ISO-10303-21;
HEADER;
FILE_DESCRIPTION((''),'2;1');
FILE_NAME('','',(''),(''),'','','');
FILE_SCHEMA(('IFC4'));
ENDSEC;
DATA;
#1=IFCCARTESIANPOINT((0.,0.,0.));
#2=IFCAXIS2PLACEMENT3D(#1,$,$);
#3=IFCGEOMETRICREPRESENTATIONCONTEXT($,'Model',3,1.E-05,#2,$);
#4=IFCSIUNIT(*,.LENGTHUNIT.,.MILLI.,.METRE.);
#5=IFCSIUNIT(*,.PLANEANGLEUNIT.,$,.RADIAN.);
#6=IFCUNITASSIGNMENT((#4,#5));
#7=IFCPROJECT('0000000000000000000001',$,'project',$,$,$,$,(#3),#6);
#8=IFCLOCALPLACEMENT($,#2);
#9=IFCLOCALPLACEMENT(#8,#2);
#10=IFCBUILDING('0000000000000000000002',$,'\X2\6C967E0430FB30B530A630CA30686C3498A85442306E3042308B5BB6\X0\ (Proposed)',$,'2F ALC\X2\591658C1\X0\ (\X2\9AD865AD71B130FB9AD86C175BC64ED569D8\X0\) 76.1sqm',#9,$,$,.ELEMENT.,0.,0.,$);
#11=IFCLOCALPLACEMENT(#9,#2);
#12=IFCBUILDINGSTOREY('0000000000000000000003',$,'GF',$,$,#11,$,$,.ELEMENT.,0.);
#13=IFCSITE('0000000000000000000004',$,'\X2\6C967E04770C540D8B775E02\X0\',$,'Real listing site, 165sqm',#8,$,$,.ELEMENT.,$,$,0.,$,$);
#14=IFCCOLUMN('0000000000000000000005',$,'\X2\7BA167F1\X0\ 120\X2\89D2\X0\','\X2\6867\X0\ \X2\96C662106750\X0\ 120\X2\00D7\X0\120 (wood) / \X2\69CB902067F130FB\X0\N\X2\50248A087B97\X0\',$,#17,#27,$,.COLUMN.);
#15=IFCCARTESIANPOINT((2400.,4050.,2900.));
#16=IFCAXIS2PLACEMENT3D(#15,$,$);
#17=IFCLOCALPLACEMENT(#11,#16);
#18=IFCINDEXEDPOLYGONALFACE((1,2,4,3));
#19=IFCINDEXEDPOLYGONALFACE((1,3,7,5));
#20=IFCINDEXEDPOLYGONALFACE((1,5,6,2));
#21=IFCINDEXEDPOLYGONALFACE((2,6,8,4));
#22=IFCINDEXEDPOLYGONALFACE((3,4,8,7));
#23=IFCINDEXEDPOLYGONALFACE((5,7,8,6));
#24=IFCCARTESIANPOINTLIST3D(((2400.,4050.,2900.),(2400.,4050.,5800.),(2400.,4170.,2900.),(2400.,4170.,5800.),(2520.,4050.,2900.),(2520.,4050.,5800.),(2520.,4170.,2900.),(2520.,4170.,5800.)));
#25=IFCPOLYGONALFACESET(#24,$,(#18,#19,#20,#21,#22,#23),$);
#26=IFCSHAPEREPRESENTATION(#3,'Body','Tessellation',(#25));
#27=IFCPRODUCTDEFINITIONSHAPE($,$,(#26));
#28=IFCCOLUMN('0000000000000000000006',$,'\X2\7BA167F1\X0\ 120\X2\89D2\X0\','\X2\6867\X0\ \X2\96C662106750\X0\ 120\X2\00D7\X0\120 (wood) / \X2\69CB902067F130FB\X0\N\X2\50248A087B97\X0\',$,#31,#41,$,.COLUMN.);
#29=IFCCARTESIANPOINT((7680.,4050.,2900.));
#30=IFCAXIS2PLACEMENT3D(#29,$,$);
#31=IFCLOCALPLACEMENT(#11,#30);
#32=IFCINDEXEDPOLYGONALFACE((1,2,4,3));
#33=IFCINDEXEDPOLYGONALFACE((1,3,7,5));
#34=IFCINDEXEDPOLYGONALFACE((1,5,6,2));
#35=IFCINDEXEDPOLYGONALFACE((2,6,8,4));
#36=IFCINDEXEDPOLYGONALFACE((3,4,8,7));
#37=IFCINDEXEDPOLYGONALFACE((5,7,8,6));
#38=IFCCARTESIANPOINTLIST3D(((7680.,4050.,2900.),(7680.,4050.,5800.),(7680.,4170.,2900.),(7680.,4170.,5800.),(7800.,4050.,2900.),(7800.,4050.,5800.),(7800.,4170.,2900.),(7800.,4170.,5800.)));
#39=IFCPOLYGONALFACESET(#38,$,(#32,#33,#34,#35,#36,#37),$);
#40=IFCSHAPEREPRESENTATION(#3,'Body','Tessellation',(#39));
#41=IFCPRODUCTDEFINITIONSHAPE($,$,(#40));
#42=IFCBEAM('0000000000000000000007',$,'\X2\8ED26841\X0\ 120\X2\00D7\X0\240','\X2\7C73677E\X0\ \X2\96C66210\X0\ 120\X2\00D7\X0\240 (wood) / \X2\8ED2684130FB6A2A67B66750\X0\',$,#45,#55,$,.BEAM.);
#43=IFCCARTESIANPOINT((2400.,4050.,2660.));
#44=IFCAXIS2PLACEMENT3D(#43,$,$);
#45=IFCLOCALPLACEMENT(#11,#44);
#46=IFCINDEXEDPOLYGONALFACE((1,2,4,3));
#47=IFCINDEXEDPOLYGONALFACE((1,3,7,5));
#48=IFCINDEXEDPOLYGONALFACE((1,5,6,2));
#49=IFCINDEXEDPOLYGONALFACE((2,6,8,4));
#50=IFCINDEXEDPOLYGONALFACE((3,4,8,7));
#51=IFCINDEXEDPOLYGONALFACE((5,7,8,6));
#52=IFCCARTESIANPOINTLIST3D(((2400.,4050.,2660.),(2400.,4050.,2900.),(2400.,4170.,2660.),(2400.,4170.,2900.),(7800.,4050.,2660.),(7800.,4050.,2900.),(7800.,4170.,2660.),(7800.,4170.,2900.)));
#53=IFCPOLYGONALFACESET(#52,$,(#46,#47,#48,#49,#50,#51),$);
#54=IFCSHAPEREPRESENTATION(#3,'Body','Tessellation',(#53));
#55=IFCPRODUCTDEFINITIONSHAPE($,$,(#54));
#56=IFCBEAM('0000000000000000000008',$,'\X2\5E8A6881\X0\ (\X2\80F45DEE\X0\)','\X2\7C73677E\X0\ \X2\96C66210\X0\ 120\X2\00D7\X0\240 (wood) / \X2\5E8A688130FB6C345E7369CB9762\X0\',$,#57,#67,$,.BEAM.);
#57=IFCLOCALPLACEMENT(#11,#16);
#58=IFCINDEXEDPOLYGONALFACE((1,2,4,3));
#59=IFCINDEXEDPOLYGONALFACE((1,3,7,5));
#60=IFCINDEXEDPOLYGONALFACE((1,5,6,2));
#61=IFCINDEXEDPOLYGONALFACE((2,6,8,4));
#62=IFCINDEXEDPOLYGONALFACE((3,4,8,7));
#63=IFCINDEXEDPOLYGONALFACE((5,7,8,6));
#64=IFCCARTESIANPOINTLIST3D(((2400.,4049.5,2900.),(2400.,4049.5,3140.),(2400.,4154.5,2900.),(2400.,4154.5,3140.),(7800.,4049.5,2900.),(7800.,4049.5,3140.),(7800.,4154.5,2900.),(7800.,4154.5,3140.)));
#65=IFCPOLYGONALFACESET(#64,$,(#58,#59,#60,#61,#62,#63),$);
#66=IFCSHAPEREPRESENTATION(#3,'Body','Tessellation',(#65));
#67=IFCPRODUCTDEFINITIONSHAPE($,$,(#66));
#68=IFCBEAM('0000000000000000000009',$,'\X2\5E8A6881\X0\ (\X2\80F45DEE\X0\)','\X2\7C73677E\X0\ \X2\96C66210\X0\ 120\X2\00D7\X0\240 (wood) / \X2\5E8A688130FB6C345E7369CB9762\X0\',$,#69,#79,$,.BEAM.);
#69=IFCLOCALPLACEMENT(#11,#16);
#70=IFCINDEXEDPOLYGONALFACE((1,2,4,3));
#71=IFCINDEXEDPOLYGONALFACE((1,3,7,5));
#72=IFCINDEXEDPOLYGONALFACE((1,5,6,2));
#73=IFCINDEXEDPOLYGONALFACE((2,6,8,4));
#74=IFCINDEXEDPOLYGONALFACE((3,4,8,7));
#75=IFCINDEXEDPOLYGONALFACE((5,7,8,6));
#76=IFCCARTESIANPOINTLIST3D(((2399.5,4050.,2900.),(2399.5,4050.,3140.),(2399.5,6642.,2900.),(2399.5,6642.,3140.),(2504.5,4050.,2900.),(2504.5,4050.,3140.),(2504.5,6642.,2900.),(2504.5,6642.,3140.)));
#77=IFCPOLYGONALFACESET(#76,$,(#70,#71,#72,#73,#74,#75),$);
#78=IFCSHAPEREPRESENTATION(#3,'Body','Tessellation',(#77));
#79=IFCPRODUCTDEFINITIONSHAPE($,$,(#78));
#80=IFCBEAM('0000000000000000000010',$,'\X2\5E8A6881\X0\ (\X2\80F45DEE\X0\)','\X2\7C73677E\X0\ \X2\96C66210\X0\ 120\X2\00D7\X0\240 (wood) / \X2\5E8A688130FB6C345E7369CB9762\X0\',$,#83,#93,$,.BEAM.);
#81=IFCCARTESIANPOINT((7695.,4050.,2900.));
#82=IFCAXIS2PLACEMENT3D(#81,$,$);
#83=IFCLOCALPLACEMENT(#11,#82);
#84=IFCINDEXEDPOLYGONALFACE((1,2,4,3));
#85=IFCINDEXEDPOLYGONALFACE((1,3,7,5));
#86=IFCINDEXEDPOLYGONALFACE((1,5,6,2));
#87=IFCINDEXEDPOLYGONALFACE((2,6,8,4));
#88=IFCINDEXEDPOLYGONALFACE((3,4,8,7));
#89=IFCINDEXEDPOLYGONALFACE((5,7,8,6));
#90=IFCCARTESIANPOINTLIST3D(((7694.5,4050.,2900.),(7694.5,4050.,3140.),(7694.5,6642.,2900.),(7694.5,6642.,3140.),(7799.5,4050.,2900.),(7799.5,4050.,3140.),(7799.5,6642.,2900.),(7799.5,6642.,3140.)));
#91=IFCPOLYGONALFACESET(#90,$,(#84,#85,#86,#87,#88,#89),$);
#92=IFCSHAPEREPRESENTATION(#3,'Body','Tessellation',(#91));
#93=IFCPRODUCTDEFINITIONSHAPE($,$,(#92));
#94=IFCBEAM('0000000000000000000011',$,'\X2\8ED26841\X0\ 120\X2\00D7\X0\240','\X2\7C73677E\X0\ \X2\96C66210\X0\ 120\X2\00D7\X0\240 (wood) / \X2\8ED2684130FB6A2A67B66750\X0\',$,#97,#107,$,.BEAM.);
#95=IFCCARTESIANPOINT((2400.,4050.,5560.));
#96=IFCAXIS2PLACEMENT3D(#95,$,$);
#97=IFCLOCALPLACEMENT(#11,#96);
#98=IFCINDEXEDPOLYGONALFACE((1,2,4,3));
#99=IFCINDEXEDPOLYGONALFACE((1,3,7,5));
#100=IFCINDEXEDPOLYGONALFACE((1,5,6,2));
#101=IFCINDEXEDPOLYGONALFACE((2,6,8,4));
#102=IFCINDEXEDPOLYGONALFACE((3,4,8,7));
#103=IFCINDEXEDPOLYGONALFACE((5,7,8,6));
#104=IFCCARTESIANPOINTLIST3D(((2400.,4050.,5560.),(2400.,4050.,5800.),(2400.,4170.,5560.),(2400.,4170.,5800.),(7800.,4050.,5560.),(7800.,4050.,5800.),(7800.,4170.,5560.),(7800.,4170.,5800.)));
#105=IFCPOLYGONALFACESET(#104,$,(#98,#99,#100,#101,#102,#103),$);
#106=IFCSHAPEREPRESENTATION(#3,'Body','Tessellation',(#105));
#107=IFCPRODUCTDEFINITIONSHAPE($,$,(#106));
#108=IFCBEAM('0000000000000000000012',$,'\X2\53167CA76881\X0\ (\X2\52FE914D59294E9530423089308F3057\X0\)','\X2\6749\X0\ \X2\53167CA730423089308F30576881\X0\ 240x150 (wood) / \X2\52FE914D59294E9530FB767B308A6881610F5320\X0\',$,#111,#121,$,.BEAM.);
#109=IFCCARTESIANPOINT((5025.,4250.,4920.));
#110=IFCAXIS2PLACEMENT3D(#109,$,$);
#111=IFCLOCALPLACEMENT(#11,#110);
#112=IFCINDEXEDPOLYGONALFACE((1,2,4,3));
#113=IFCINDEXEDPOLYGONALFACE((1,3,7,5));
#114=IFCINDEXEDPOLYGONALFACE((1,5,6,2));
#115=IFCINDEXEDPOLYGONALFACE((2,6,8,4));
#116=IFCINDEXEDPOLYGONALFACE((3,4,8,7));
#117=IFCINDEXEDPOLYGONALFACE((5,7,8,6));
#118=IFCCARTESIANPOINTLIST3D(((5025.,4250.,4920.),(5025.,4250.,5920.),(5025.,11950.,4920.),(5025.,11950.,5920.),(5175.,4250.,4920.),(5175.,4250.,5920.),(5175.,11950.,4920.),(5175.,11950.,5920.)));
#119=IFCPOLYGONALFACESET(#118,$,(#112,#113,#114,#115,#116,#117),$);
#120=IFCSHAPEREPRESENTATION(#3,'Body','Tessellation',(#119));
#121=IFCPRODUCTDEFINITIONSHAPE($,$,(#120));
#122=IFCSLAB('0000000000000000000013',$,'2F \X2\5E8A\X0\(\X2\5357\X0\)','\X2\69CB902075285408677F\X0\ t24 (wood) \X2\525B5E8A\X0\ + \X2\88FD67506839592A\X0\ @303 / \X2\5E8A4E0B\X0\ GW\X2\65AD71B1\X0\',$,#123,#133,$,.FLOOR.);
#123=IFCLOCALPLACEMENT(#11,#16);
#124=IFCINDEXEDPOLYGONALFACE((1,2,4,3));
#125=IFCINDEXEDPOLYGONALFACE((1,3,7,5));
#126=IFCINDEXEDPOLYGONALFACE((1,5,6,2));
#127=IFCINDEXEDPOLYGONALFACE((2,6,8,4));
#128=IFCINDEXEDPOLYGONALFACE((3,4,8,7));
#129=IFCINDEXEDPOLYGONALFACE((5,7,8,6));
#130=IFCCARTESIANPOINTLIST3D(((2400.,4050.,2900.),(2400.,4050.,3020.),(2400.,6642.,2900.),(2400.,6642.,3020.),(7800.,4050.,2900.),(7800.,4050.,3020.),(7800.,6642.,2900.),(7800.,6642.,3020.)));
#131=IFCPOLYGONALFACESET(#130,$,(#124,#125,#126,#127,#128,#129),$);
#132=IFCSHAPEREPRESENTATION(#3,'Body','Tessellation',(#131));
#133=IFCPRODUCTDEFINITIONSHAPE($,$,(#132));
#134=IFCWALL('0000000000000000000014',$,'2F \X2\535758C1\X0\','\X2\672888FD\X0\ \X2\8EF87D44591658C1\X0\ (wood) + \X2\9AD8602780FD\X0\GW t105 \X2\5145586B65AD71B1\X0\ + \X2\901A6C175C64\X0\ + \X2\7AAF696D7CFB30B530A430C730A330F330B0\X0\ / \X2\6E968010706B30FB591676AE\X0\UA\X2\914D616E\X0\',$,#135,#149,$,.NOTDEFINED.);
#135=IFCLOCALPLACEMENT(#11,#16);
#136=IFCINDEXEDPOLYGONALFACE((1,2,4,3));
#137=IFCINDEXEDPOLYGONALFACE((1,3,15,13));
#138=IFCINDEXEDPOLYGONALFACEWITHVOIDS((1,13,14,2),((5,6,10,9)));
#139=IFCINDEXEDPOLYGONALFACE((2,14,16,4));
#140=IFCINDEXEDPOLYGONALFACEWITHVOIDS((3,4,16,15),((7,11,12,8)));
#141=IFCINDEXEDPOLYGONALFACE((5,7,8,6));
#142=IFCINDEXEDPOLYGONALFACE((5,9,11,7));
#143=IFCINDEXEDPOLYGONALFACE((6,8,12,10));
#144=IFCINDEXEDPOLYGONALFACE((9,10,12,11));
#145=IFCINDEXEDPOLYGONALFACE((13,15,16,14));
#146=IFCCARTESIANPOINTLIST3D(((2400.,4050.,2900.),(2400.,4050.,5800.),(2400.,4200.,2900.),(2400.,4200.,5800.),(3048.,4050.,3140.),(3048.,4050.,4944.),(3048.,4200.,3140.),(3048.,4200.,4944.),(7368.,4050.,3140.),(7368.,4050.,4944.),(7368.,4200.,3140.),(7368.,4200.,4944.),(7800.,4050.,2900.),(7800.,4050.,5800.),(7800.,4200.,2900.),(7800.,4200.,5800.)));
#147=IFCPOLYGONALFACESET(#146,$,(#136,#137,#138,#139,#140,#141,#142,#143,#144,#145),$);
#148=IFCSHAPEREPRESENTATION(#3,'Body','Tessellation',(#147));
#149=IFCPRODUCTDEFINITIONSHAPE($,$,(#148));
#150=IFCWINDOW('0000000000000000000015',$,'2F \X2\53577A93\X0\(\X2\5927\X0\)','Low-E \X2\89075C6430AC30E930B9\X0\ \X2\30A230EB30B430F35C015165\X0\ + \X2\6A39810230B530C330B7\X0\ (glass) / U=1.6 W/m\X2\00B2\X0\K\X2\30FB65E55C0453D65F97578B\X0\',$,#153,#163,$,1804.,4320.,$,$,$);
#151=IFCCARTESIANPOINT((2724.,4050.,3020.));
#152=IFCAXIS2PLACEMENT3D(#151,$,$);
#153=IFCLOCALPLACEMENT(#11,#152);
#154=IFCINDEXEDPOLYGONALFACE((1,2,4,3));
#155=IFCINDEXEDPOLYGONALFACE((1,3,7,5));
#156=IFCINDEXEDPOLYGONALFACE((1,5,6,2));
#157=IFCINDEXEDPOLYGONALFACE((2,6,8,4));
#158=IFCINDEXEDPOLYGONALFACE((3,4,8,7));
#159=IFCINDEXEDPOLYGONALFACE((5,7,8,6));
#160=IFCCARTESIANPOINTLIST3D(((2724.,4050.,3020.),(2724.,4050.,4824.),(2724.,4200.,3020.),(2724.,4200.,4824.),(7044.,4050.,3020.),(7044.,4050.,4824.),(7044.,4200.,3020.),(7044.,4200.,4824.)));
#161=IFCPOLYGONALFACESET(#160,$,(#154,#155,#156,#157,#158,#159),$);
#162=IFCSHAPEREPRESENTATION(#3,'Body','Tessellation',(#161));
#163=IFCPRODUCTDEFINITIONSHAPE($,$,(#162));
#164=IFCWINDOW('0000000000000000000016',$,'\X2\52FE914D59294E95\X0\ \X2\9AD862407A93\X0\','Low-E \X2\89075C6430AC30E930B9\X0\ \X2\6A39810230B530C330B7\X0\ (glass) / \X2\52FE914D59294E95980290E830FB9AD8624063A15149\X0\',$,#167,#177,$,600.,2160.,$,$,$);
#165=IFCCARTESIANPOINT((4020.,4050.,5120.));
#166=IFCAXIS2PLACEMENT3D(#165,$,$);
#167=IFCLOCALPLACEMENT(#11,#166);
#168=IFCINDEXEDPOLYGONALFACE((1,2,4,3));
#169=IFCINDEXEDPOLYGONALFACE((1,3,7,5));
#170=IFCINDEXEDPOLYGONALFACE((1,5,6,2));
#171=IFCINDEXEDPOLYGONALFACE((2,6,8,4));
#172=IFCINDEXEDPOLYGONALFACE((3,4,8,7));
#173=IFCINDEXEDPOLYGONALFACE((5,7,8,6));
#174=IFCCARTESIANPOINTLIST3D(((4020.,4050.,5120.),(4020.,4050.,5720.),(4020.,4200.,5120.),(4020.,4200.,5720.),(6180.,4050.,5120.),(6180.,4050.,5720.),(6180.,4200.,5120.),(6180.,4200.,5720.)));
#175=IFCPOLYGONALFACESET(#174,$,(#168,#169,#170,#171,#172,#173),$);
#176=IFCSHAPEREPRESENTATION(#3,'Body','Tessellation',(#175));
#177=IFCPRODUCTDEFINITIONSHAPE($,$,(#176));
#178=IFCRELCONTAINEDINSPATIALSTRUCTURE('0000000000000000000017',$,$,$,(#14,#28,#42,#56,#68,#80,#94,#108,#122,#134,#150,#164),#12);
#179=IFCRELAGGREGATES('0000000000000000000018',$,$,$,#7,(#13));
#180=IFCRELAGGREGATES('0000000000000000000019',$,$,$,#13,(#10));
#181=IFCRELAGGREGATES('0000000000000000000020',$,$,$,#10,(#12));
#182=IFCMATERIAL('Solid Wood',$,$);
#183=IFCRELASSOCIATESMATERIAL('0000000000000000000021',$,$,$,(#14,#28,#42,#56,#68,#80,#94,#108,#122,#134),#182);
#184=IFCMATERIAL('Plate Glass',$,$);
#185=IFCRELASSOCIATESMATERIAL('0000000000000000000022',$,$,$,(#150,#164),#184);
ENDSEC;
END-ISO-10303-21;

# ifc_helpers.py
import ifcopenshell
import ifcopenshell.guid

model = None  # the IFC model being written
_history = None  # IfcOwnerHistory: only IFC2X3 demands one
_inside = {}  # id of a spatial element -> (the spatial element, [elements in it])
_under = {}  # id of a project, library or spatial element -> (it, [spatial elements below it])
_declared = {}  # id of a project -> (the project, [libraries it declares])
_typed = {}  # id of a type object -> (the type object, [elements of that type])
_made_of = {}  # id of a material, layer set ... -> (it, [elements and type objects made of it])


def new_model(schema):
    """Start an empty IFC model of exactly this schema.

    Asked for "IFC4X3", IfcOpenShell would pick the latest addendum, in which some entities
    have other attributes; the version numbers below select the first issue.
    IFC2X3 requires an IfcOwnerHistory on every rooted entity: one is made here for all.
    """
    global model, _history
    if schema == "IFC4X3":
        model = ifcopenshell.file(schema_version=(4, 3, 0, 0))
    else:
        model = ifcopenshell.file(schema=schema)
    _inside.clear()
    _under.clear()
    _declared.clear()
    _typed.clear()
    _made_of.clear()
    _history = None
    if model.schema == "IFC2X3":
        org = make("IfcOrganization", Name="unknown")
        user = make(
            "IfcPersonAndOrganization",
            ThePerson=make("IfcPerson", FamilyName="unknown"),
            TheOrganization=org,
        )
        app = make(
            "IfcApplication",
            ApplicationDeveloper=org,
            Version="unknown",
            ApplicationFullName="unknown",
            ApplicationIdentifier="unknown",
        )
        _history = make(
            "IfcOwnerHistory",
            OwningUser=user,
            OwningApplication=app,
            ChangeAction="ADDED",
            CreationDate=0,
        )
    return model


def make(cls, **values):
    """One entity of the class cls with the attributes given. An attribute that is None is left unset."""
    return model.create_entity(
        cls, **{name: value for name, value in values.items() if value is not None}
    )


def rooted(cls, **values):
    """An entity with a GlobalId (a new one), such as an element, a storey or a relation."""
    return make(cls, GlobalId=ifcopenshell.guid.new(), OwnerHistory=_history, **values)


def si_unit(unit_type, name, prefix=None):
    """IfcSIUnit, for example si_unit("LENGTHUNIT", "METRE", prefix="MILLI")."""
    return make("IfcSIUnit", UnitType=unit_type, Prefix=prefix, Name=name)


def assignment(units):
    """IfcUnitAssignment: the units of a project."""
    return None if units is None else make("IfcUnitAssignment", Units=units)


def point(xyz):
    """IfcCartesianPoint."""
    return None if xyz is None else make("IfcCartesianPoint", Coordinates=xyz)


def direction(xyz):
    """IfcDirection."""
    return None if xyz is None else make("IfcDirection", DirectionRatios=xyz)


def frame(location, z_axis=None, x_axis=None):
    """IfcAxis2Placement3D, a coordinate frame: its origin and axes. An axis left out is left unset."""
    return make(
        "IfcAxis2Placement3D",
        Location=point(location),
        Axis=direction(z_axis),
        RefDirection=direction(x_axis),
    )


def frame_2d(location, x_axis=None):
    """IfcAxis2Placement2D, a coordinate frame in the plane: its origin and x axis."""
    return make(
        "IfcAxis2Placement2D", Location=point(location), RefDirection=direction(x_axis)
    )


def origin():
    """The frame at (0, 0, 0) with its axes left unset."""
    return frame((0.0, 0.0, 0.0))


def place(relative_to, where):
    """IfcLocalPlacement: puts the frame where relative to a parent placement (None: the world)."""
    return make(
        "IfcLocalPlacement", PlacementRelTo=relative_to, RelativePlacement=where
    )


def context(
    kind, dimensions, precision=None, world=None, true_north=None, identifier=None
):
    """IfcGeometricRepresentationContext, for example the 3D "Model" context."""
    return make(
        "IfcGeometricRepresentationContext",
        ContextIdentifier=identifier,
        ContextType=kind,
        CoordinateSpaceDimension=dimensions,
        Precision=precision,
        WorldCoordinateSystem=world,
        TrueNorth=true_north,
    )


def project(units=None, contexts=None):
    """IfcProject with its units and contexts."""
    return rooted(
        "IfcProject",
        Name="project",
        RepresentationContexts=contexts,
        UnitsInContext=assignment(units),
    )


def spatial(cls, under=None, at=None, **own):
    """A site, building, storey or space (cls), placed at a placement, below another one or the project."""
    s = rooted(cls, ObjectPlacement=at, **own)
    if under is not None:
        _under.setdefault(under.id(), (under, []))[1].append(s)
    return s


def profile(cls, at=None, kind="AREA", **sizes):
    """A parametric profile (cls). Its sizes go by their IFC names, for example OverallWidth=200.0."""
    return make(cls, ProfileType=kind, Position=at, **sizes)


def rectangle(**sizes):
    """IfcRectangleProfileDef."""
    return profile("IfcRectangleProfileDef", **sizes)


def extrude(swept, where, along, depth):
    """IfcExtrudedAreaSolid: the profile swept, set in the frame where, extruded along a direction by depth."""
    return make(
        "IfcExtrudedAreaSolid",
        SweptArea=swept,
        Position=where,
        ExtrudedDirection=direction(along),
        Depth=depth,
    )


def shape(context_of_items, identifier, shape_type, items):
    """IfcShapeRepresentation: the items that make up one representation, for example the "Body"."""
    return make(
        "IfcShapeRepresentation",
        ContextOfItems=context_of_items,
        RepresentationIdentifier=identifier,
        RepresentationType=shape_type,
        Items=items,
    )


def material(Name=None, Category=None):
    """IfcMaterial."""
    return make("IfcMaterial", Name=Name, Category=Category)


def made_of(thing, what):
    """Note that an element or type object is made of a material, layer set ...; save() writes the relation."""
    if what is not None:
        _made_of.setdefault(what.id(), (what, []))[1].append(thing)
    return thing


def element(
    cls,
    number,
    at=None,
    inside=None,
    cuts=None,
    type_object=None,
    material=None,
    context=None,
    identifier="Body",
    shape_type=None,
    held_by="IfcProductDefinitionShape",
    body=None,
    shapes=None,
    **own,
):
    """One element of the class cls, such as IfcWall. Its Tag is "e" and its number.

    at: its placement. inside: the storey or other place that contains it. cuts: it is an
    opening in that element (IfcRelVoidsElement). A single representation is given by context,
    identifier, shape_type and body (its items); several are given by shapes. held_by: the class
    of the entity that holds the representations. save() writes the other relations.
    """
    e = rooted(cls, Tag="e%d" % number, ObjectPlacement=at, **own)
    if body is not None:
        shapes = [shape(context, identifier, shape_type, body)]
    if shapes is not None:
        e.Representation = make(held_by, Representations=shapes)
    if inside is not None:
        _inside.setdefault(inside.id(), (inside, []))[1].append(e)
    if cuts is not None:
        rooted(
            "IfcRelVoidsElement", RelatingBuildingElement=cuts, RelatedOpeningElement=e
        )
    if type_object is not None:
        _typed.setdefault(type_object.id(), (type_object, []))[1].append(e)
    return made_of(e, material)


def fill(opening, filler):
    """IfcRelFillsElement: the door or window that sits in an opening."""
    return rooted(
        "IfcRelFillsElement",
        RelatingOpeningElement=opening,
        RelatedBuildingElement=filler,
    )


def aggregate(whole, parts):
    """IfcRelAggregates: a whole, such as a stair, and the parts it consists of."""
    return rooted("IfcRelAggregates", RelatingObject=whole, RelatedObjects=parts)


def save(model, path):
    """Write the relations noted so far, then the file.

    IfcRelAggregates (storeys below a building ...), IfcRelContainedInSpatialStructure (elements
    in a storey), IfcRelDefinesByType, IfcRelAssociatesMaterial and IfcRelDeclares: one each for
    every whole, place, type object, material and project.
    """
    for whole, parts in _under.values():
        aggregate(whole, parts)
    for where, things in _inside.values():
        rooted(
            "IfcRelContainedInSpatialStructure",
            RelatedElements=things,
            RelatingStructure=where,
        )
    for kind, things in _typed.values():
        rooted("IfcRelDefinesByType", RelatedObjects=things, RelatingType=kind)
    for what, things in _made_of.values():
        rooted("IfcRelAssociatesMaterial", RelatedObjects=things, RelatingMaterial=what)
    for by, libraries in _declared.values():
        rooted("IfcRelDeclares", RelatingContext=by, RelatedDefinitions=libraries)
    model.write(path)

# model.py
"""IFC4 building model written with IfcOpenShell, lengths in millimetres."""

from ifc_helpers import new_model, si_unit, frame, frame_2d, origin, place, context, project, spatial, rectangle, extrude, material, element, fill, save


model = new_model("IFC4")

# Units and contexts
model_context = context("Model", 3, precision=1e-05, world=origin())
ifc_project = project(units=[si_unit("LENGTHUNIT", "METRE", prefix="MILLI"), si_unit("PLANEANGLEUNIT", "RADIAN")], contexts=[model_context])

# Site, building, storey
site_placement = place(None, origin())
site = spatial("IfcSite", under=ifc_project, at=site_placement, Name="沖縄県名護市", ObjectType="Real listing site, 165sqm", CompositionType="ELEMENT", RefElevation=0.0)
building_placement = place(site_placement, origin())
building = spatial("IfcBuilding", under=site, at=building_placement, Name="沖縄・サウナと水風呂のある家 (Proposed)", ObjectType="2F ALC外壁 (高断熱・高気密仕様) 76.1sqm", CompositionType="ELEMENT", ElevationOfRefHeight=0.0, ElevationOfTerrain=0.0)
storey_placement = place(building_placement, origin())
storey = spatial("IfcBuildingStorey", under=building, at=storey_placement, Name="GF", CompositionType="ELEMENT", Elevation=0.0)

# Columns
ifc_material_1 = material(Name="Solid Wood")
column_1_placement = place(storey_placement, frame((2400.0, 4050.0, 2900.0)))
element("IfcColumn", 1, at=column_1_placement, inside=storey, material=ifc_material_1, Name="管柱 120角", Description="桧 集成材 120×120 (wood) / 構造柱・N値計算", PredefinedType="COLUMN", context=model_context, shape_type="SweptSolid", body=[
    extrude(rectangle(XDim=120.0, YDim=120.0, at=frame_2d((60.0, 60.0))), frame((2400.0, 4050.0, 2900.0)), (0.0, 0.0, 1.0), 2900.0),
])
column_2_placement = place(storey_placement, frame((7680.0, 4050.0, 2900.0)))
element("IfcColumn", 2, at=column_2_placement, inside=storey, material=ifc_material_1, Name="管柱 120角", Description="桧 集成材 120×120 (wood) / 構造柱・N値計算", PredefinedType="COLUMN", context=model_context, shape_type="SweptSolid", body=[
    extrude(rectangle(XDim=120.0, YDim=120.0, at=frame_2d((60.0, 60.0))), frame((7680.0, 4050.0, 2900.0)), (0.0, 0.0, 1.0), 2900.0),
])

# Beams
beam_1_placement = place(storey_placement, frame((2400.0, 4050.0, 2660.0)))
element("IfcBeam", 3, at=beam_1_placement, inside=storey, material=ifc_material_1, Name="軒桁 120×240", Description="米松 集成 120×240 (wood) / 軒桁・横架材", PredefinedType="BEAM", context=model_context, shape_type="SweptSolid", body=[
    extrude(rectangle(XDim=5400.0, YDim=120.0, at=frame_2d((2700.0, 60.0))), frame((2400.0, 4050.0, 2660.0)), (0.0, 0.0, 1.0), 240.0),
])
beam_2_placement = place(storey_placement, frame((2400.0, 4050.0, 2900.0)))
element("IfcBeam", 4, at=beam_2_placement, inside=storey, material=ifc_material_1, Name="床梁 (胴差)", Description="米松 集成 120×240 (wood) / 床梁・水平構面", PredefinedType="BEAM", context=model_context, shape_type="SweptSolid", body=[
    extrude(rectangle(XDim=5400.0, YDim=105.0, at=frame_2d((2700.0, 52.0))), frame((2400.0, 4050.0, 2900.0)), (0.0, 0.0, 1.0), 240.0),
])
beam_3_placement = place(storey_placement, frame((2400.0, 4050.0, 2900.0)))
element("IfcBeam", 5, at=beam_3_placement, inside=storey, material=ifc_material_1, Name="床梁 (胴差)", Description="米松 集成 120×240 (wood) / 床梁・水平構面", PredefinedType="BEAM", context=model_context, shape_type="SweptSolid", body=[
    extrude(rectangle(XDim=105.0, YDim=2592.0, at=frame_2d((52.0, 1296.0))), frame((2400.0, 4050.0, 2900.0)), (0.0, 0.0, 1.0), 240.0),
])
beam_4_placement = place(storey_placement, frame((7695.0, 4050.0, 2900.0)))
element("IfcBeam", 6, at=beam_4_placement, inside=storey, material=ifc_material_1, Name="床梁 (胴差)", Description="米松 集成 120×240 (wood) / 床梁・水平構面", PredefinedType="BEAM", context=model_context, shape_type="SweptSolid", body=[
    extrude(rectangle(XDim=105.0, YDim=2592.0, at=frame_2d((52.0, 1296.0))), frame((7695.0, 4050.0, 2900.0)), (0.0, 0.0, 1.0), 240.0),
])
beam_5_placement = place(storey_placement, frame((2400.0, 4050.0, 5560.0)))
element("IfcBeam", 7, at=beam_5_placement, inside=storey, material=ifc_material_1, Name="軒桁 120×240", Description="米松 集成 120×240 (wood) / 軒桁・横架材", PredefinedType="BEAM", context=model_context, shape_type="SweptSolid", body=[
    extrude(rectangle(XDim=5400.0, YDim=120.0, at=frame_2d((2700.0, 60.0))), frame((2400.0, 4050.0, 5560.0)), (0.0, 0.0, 1.0), 240.0),
])
beam_6_placement = place(storey_placement, frame((5025.0, 4250.0, 4920.0)))
element("IfcBeam", 8, at=beam_6_placement, inside=storey, material=ifc_material_1, Name="化粧梁 (勾配天井あらわし)", Description="杉 化粧あらわし梁 240x150 (wood) / 勾配天井・登り梁意匠", PredefinedType="BEAM", context=model_context, shape_type="SweptSolid", body=[
    extrude(rectangle(XDim=150.0, YDim=7700.0, at=frame_2d((75.0, 3850.0))), frame((5025.0, 4250.0, 4920.0)), (0.0, 0.0, 1.0), 1000.0),
])

# Slab
slab_placement = place(storey_placement, frame((2400.0, 4050.0, 2900.0)))
element("IfcSlab", 9, at=slab_placement, inside=storey, material=ifc_material_1, Name="2F 床(南)", Description="構造用合板 t24 (wood) 剛床 + 製材根太 @303 / 床下 GW断熱", PredefinedType="FLOOR", context=model_context, shape_type="SweptSolid", body=[
    extrude(rectangle(XDim=5400.0, YDim=2592.0, at=frame_2d((2700.0, 1296.0))), frame((2400.0, 4050.0, 2900.0)), (0.0, 0.0, 1.0), 120.0),
])

# Wall, openings, windows
wall_1_placement = place(storey_placement, frame((2400.0, 4050.0, 2900.0)))
wall_1 = element("IfcWall", 10, at=wall_1_placement, inside=storey, material=ifc_material_1, Name="2F 南壁", Description="木製 軸組外壁 (wood) + 高性能GW t105 充填断熱 + 通気層 + 窯業系サイディング / 準耐火・外皮UA配慮", PredefinedType="NOTDEFINED", context=model_context, shape_type="SweptSolid", body=[
    extrude(rectangle(XDim=5400.0, YDim=150.0, at=frame_2d((2700.0, 75.0))), frame((2400.0, 4050.0, 2900.0)), (0.0, 0.0, 1.0), 2900.0),
])
opening_1_placement = place(storey_placement, frame((2724.0, 4050.0, 3020.0)))
opening_1 = element("IfcOpeningElement", 11, at=opening_1_placement, cuts=wall_1, PredefinedType="NOTDEFINED", context=model_context, shape_type="SweptSolid", body=[
    extrude(rectangle(XDim=4320.0, YDim=150.0, at=frame_2d((2160.0, 75.0))), frame((2724.0, 4050.0, 3020.0)), (0.0, 0.0, 1.0), 1804.0),
])
opening_2_placement = place(storey_placement, frame((4020.0, 4050.0, 5120.0)))
opening_2 = element("IfcOpeningElement", 12, at=opening_2_placement, cuts=wall_1, PredefinedType="NOTDEFINED", context=model_context, shape_type="SweptSolid", body=[
    extrude(rectangle(XDim=2160.0, YDim=150.0, at=frame_2d((1080.0, 75.0))), frame((4020.0, 4050.0, 5120.0)), (0.0, 0.0, 1.0), 600.0),
])
ifc_material_2 = material(Name="Plate Glass")
window_1_placement = place(storey_placement, frame((2724.0, 4050.0, 3020.0)))
window_1 = element("IfcWindow", 13, at=window_1_placement, inside=storey, material=ifc_material_2, Name="2F 南窓(大)", Description="Low-E 複層ガラス アルゴン封入 + 樹脂サッシ (glass) / U=1.6 W/m²K・日射取得型", OverallHeight=1804.0, OverallWidth=4320.0, context=model_context, shape_type="SweptSolid", body=[
    extrude(rectangle(XDim=4320.0, YDim=150.0, at=frame_2d((2160.0, 75.0))), frame((2724.0, 4050.0, 3020.0)), (0.0, 0.0, 1.0), 1804.0),
])
fill(opening_1, window_1)
window_2_placement = place(storey_placement, frame((4020.0, 4050.0, 5120.0)))
window_2 = element("IfcWindow", 14, at=window_2_placement, inside=storey, material=ifc_material_2, Name="勾配天井 高所窓", Description="Low-E 複層ガラス 樹脂サッシ (glass) / 勾配天井頂部・高所採光", OverallHeight=600.0, OverallWidth=2160.0, context=model_context, shape_type="SweptSolid", body=[
    extrude(rectangle(XDim=2160.0, YDim=150.0, at=frame_2d((1080.0, 75.0))), frame((4020.0, 4050.0, 5120.0)), (0.0, 0.0, 1.0), 600.0),
])
fill(opening_2, window_2)

save(model, "model.ifc")
